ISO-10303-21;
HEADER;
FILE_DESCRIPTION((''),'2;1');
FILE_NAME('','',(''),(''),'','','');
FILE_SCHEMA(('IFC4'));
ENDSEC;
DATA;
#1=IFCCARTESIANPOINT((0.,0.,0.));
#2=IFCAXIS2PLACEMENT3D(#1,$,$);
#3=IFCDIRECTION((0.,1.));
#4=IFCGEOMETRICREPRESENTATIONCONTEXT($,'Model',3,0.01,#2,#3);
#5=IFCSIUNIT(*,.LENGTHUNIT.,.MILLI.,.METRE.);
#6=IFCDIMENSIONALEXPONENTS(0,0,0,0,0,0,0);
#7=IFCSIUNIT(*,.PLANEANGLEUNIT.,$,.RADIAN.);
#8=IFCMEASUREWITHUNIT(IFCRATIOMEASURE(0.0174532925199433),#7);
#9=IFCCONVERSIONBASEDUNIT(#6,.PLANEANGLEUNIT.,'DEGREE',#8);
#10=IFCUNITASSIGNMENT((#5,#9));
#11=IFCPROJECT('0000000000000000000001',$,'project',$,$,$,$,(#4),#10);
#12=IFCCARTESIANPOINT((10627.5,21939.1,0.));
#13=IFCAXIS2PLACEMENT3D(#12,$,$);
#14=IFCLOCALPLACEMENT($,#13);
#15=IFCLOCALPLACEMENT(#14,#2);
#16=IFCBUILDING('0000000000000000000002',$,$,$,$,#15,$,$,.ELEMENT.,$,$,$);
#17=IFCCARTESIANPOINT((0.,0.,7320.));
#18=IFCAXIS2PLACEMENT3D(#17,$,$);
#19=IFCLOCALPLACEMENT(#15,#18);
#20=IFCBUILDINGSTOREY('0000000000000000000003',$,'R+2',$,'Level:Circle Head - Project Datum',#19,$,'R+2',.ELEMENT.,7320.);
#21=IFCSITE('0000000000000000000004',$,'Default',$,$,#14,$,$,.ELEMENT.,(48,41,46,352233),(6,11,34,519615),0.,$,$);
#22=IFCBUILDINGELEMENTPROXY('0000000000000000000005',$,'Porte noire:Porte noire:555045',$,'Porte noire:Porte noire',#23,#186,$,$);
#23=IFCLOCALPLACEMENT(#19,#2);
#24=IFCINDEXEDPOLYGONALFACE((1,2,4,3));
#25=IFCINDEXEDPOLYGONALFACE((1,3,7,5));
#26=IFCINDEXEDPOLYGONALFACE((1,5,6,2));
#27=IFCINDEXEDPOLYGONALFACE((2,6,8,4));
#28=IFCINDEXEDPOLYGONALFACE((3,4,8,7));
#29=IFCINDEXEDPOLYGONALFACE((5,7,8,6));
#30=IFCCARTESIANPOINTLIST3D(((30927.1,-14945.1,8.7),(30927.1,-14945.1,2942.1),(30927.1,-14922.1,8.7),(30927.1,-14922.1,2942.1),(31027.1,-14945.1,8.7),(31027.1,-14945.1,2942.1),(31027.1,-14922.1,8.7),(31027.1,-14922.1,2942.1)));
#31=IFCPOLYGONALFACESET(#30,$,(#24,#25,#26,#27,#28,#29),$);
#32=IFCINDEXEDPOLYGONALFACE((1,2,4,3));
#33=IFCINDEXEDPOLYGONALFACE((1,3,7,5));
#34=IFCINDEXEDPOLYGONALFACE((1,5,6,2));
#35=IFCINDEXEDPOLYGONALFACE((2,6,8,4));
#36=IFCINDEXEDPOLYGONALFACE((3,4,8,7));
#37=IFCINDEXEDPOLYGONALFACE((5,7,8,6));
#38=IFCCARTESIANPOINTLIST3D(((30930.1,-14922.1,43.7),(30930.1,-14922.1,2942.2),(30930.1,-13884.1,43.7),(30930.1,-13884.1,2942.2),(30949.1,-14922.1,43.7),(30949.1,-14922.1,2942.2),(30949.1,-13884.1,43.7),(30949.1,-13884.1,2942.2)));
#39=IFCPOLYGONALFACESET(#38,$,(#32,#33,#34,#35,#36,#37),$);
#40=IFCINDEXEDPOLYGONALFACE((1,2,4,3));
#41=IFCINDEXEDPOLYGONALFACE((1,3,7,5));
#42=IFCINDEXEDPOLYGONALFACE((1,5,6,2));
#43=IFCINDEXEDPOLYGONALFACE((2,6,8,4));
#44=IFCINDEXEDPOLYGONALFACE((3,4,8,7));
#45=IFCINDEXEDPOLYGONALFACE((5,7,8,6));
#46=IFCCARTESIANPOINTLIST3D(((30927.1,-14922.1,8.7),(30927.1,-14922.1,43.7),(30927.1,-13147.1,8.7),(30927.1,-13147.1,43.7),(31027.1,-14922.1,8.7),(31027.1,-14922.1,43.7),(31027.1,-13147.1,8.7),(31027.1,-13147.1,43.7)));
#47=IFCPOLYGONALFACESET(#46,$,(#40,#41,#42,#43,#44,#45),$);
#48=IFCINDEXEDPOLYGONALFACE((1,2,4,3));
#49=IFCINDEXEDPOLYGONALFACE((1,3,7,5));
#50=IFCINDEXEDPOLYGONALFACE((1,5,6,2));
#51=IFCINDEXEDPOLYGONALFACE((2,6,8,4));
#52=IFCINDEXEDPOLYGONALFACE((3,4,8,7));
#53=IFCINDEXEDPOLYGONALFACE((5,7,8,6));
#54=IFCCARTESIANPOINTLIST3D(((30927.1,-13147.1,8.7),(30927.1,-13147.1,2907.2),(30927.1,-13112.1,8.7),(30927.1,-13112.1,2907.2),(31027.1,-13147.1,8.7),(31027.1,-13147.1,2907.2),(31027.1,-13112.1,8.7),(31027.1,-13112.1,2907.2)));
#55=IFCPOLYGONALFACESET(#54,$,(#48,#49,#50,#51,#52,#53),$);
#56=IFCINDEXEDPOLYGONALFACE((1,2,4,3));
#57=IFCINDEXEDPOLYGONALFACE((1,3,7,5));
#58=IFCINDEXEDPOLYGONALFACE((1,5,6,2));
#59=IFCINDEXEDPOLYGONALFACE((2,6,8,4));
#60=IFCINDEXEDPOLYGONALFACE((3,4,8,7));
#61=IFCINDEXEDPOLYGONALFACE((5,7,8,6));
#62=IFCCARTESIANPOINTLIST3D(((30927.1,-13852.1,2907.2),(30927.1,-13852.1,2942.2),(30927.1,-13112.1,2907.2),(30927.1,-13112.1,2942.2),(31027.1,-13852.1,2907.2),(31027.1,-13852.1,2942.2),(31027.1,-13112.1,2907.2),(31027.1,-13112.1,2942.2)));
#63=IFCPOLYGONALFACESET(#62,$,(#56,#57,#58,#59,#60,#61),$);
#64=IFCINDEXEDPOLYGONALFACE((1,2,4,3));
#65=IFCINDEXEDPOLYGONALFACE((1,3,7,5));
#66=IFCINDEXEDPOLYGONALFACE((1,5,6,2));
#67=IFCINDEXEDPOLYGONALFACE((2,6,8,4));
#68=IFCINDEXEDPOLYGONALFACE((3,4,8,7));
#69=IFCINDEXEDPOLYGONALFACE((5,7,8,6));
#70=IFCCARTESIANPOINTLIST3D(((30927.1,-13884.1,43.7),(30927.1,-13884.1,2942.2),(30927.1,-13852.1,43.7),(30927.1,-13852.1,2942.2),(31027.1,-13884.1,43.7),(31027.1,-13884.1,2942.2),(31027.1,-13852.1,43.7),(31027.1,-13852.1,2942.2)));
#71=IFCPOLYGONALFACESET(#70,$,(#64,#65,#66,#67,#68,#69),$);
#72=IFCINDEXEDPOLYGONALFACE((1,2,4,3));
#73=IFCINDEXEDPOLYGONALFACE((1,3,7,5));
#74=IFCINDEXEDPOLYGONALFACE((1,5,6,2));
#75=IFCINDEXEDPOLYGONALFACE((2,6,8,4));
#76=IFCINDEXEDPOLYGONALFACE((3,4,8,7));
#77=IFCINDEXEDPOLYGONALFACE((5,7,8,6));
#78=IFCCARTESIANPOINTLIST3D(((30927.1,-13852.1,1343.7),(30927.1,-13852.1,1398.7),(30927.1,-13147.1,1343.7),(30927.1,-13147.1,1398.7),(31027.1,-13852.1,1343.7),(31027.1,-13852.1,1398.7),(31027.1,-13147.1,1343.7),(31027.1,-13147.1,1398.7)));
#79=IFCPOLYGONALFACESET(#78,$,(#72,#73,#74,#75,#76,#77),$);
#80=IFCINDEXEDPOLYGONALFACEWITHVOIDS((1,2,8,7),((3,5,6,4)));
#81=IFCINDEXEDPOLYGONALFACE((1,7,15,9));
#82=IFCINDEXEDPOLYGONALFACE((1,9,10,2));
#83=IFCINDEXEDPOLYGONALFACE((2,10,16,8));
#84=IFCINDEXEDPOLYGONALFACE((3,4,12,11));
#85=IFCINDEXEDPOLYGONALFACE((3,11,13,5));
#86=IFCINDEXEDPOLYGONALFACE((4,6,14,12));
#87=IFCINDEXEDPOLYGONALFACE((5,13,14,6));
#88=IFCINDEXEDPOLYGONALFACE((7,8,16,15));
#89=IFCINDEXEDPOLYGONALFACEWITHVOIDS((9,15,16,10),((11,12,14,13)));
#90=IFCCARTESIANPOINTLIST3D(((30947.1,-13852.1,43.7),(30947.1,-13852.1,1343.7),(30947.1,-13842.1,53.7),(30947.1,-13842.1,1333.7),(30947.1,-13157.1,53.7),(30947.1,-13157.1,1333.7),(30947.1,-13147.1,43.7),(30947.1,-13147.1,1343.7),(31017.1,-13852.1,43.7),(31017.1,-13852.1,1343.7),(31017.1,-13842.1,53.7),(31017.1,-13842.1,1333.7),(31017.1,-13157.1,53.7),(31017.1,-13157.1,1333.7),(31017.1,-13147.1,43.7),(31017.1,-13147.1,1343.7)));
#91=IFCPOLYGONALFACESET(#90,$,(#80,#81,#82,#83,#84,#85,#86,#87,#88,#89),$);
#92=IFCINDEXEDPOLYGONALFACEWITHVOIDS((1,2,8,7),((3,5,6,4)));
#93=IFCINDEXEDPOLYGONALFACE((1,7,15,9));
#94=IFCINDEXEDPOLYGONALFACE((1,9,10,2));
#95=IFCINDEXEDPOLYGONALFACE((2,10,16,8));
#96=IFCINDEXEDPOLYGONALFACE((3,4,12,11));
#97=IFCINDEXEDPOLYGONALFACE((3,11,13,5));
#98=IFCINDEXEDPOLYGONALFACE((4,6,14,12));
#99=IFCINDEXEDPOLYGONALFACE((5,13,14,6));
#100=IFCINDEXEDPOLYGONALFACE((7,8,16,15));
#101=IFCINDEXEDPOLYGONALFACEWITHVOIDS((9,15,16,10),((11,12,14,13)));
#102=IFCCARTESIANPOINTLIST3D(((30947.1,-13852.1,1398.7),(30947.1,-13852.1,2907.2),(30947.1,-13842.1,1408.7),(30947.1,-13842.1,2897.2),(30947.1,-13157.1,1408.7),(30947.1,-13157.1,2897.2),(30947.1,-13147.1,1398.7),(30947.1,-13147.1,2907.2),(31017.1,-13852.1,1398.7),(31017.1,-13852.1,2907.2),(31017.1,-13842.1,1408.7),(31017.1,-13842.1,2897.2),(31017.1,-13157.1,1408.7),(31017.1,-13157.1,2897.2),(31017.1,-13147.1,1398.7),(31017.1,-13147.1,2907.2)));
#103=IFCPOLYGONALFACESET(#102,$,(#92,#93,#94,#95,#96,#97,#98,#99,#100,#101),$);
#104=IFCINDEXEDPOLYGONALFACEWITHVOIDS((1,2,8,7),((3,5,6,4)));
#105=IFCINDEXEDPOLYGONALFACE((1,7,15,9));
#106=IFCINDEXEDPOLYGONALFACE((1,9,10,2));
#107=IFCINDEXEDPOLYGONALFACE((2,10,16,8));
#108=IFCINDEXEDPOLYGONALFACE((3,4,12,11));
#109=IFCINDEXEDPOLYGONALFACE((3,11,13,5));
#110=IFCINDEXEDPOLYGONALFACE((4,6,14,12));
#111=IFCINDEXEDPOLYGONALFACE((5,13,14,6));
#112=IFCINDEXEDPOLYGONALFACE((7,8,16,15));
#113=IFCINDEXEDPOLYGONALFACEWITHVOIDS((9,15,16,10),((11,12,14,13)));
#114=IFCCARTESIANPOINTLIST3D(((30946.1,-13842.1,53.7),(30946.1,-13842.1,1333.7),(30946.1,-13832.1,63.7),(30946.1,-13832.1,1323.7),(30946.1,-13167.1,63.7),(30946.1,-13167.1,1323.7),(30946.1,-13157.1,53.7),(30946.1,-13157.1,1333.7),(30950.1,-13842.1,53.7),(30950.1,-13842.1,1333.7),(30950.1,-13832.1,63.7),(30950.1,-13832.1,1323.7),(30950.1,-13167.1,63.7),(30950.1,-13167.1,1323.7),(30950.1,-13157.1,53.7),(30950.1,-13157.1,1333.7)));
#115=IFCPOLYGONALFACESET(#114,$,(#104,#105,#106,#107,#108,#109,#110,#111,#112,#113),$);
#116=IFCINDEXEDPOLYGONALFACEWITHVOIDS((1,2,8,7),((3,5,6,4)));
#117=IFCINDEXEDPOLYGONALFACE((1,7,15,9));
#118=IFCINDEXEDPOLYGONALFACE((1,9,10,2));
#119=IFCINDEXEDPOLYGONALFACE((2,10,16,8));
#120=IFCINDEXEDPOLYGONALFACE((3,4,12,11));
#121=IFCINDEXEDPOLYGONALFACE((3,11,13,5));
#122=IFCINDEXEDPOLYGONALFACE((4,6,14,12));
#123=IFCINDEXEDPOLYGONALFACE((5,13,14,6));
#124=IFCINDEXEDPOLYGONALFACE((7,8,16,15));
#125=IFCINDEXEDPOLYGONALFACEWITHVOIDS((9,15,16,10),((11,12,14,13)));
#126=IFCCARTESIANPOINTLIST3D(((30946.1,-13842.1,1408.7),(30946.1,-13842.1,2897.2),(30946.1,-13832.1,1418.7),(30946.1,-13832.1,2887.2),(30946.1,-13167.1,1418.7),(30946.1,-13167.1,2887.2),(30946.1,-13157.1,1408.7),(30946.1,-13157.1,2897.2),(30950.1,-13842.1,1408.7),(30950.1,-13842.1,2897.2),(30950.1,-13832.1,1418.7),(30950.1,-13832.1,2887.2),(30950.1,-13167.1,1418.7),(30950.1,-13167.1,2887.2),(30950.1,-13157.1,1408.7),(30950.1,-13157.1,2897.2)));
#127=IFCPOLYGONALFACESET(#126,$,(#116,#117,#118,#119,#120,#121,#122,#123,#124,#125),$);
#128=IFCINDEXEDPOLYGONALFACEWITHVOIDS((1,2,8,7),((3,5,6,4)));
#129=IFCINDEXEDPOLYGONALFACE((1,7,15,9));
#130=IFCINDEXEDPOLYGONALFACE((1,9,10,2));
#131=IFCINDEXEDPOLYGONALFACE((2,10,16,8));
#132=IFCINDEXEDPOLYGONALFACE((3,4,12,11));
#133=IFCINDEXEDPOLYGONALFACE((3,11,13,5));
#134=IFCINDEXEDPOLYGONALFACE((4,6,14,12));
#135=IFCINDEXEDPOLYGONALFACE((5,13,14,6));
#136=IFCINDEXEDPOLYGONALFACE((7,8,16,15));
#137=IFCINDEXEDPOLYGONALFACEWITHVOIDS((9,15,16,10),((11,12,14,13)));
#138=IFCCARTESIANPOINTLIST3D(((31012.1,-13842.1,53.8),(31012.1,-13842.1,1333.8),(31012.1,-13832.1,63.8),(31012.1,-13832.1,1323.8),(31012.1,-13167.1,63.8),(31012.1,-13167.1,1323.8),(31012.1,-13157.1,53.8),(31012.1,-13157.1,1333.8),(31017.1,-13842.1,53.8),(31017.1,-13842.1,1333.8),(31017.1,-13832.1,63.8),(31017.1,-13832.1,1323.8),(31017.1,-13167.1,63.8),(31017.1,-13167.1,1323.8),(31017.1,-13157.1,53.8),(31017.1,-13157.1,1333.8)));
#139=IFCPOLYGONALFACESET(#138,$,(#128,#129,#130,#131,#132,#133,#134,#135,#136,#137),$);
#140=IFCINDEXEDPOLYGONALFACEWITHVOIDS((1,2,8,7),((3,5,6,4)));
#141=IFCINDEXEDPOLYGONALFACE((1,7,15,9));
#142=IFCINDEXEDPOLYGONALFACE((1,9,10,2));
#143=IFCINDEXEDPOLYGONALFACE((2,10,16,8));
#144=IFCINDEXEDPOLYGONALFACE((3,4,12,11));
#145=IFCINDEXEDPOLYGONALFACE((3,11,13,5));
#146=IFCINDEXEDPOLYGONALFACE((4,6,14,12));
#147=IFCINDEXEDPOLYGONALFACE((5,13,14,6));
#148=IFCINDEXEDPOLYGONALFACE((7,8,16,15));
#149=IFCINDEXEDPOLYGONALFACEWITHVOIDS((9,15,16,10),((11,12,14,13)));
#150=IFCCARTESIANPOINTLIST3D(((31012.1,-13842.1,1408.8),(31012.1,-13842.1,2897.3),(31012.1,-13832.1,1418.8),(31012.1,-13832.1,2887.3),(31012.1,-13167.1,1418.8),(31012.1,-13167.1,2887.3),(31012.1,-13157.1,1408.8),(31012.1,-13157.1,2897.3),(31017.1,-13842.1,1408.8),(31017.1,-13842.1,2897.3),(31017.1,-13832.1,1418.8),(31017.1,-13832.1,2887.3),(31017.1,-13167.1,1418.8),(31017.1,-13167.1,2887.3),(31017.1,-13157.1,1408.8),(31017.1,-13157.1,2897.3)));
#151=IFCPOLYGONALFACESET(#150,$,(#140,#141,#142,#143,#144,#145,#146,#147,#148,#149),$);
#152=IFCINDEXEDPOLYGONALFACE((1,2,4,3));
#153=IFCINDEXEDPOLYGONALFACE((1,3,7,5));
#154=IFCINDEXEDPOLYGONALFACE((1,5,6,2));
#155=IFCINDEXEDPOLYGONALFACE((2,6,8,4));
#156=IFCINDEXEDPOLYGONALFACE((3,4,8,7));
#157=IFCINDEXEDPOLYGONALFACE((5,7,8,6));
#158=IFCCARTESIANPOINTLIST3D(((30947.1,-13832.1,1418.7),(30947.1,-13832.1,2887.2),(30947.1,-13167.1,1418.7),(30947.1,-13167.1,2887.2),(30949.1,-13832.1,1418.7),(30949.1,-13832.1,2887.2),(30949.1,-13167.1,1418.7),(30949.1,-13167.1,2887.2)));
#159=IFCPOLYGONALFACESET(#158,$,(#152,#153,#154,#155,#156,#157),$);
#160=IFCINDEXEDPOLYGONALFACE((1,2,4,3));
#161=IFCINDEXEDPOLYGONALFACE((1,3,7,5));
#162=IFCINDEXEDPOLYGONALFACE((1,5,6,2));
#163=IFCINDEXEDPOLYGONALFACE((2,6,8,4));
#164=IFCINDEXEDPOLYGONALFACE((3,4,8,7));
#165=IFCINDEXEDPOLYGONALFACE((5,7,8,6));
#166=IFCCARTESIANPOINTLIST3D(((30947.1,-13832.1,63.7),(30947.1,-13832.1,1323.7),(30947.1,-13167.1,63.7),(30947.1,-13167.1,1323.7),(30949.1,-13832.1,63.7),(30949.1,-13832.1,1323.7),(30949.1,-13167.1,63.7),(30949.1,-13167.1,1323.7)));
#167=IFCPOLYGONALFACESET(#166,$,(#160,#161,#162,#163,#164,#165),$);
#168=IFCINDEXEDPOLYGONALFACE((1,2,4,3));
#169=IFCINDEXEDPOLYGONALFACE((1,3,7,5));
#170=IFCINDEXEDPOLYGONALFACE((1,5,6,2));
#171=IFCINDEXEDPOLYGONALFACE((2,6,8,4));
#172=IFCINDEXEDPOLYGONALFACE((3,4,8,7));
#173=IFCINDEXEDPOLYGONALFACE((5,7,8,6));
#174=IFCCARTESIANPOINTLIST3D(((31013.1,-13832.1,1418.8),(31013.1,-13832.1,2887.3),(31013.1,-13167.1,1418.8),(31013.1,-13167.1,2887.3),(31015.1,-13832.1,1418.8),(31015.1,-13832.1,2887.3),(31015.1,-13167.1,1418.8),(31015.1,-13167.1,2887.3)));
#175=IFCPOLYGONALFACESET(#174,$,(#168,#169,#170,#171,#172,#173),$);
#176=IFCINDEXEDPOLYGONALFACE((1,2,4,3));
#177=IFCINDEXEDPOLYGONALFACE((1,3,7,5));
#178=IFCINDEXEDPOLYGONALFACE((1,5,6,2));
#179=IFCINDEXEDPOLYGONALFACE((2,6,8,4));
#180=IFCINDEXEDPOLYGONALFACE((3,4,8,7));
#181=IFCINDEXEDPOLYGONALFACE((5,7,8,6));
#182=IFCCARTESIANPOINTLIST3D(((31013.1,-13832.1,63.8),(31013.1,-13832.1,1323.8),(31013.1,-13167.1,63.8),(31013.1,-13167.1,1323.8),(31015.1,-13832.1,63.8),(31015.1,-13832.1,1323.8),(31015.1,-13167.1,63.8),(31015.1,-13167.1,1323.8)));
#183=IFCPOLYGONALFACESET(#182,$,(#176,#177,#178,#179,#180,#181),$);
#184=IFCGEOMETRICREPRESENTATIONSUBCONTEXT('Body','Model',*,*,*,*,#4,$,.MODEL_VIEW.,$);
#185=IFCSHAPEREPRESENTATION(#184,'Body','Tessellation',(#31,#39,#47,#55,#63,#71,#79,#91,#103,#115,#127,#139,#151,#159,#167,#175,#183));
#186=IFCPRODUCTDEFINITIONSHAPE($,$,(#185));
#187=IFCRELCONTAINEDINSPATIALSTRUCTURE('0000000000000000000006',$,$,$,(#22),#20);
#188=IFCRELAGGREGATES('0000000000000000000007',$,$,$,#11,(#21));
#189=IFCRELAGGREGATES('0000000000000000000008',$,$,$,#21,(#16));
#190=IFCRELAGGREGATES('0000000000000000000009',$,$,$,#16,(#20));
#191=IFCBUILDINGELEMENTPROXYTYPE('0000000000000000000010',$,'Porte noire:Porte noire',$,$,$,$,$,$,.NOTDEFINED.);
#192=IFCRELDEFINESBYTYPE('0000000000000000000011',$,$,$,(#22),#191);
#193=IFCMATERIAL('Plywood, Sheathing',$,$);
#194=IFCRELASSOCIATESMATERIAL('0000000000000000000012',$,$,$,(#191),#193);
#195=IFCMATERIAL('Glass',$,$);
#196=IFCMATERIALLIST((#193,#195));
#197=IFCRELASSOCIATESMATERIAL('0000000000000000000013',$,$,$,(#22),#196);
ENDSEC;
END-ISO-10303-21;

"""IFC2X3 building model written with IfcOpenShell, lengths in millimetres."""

from ifc_helpers import new_model, entity, si_unit, converted_unit, direction, frame, frame_2d, origin, origin_2d_with_axis, place, context, subcontext, project, spatial, polyline, rectangle, outline, extrude, source, transform, mapped, material, material_list, type_object, type_shapes, element, save


model = new_model("IFC2X3")

# Units and contexts
model_context = context("Model", 3, precision=0.01, world=origin(), true_north=direction((0.0, 1.0)))
body_context = subcontext(model_context, "Body", "Model", "MODEL_VIEW")
ifc_project = project(units=[si_unit("LENGTHUNIT", "METRE", prefix="MILLI"), converted_unit("PLANEANGLEUNIT", "DEGREE", entity("IfcRatioMeasure", 0.0174532925199433), si_unit("PLANEANGLEUNIT", "RADIAN"), dimensions=[0, 0, 0, 0, 0, 0, 0])], contexts=[model_context])

# Site, building, storey
site_placement = place(None, frame((10627.5, 21939.1, 0.0)))
site = spatial("IfcSite", under=ifc_project, at=site_placement, Name="Default", CompositionType="ELEMENT", RefLatitude=(48, 41, 46, 352233), RefLongitude=(6, 11, 34, 519615), RefElevation=0.0)
building_placement = place(site_placement, origin())
building = spatial("IfcBuilding", under=site, at=building_placement, CompositionType="ELEMENT")
storey_placement = place(building_placement, frame((0.0, 0.0, 7320.0)))
storey = spatial("IfcBuildingStorey", under=building, at=storey_placement, Name="R+2", ObjectType="Level:Circle Head - Project Datum", LongName="R+2", CompositionType="ELEMENT", Elevation=7320.0)

# Building element proxy
ifc_material_1 = material(Name="Plywood, Sheathing")
ifc_material_2 = material(Name="Glass")
ifc_material_list_1 = material_list([ifc_material_1, ifc_material_2])
building_element_proxy_type_1 = type_object("IfcBuildingElementProxyType", Name="Porte noire:Porte noire", PredefinedType="NOTDEFINED", material=ifc_material_1)
shared_shape_1 = source(origin(), body_context, "Body", "SweptSolid", [
    extrude(rectangle(XDim=23.0, YDim=100.0, at=frame_2d((0.0, 0.0), x_axis=(1.0, 0.0))), frame((-950.9, 50.0, 8.7), z_axis=(0.0, 0.0, 1.0), x_axis=(-1.0, 0.0, 0.0)), (0.0, 0.0, 1.0), 2933.3),
    extrude(rectangle(XDim=1038.0, YDim=19.0, at=frame_2d((0.0, 0.0), x_axis=(1.0, 0.0))), frame((-420.4, 87.5, 43.7), z_axis=(0.0, 0.0, 1.0), x_axis=(-1.0, 0.0, 0.0)), (0.0, 0.0, 1.0), 2898.5),
    extrude(rectangle(XDim=1775.0, YDim=100.0, at=origin_2d_with_axis()), frame((-51.9, 50.0, 8.7), z_axis=(0.0, 0.0, 1.0), x_axis=(-1.0, 0.0, 0.0)), (0.0, 0.0, 1.0), 35.0),
    extrude(rectangle(XDim=35.0, YDim=100.0, at=origin_2d_with_axis()), frame((853.1, 50.0, 8.7), z_axis=(0.0, 0.0, 1.0), x_axis=(-1.0, 0.0, 0.0)), (0.0, 0.0, 1.0), 2898.5),
    extrude(rectangle(XDim=740.0, YDim=100.0, at=origin_2d_with_axis()), frame((500.6, 50.0, 2907.2), z_axis=(0.0, 0.0, 1.0), x_axis=(-1.0, 0.0, 0.0)), (0.0, 0.0, 1.0), 35.0),
    extrude(rectangle(XDim=32.0, YDim=100.0, at=origin_2d_with_axis()), frame((114.6, 50.0, 43.7), z_axis=(0.0, 0.0, 1.0), x_axis=(-1.0, 0.0, 0.0)), (0.0, 0.0, 1.0), 2898.5),
    extrude(rectangle(XDim=705.0, YDim=100.0, at=origin_2d_with_axis()), frame((483.1, 50.0, 1343.7), z_axis=(0.0, 0.0, 1.0), x_axis=(-1.0, 0.0, 0.0)), (0.0, 0.0, 1.0), 55.0),
    extrude(outline(polyline([(-352.5, -650.0), (352.5, -650.0), (352.5, 650.0), (-352.5, 650.0), (-352.5, -650.0)]), holes=[polyline([(342.5, 640.0), (342.5, -640.0), (-342.5, -640.0), (-342.5, 640.0), (342.5, 640.0)])]), frame((483.1, 10.0, 693.7), z_axis=(0.0, 1.0, 0.0), x_axis=(1.0, 0.0, 0.0)), (0.0, 0.0, 1.0), 70.0),
    extrude(outline(polyline([(-754.2, -352.5), (754.2, -352.5), (754.2, 352.5), (-754.2, 352.5), (-754.2, -352.5)]), holes=[polyline([(744.2, 342.5), (744.2, -342.5), (-744.2, -342.5), (-744.2, 342.5), (744.2, 342.5)])]), frame((483.1, 10.0, 2153.0), z_axis=(0.0, 1.0, 0.0), x_axis=(0.0, 0.0, 1.0)), (0.0, 0.0, 1.0), 70.0),
    extrude(outline(polyline([(-640.0, -342.5), (640.0, -342.5), (640.0, 342.5), (-640.0, 342.5), (-640.0, -342.5)]), holes=[polyline([(630.0, 332.5), (630.0, -332.5), (-630.0, -332.5), (-630.0, 332.5), (630.0, 332.5)])]), frame((483.1, 77.0, 693.7), z_axis=(0.0, 1.0, 0.0), x_axis=(0.0, 0.0, 1.0)), (0.0, 0.0, 1.0), 4.0),
    extrude(outline(polyline([(-744.2, -342.5), (744.2, -342.5), (744.2, 342.5), (-744.2, 342.5), (-744.2, -342.5)]), holes=[polyline([(734.2, 332.5), (734.2, -332.5), (-734.2, -332.5), (-734.2, 332.5), (734.2, 332.5)])]), frame((483.1, 77.0, 2153.0), z_axis=(0.0, 1.0, 0.0), x_axis=(0.0, 0.0, 1.0)), (0.0, 0.0, 1.0), 4.0),
    extrude(outline(polyline([(-640.0, -342.5), (640.0, -342.5), (640.0, 342.5), (-640.0, 342.5), (-640.0, -342.5)]), holes=[polyline([(630.0, 332.5), (630.0, -332.5), (-630.0, -332.5), (-630.0, 332.5), (630.0, 332.5)])]), frame((483.1, 10.0, 693.8), z_axis=(0.0, 1.0, 0.0), x_axis=(0.0, 0.0, 1.0)), (0.0, 0.0, 1.0), 5.0),
    extrude(outline(polyline([(-744.2, -342.5), (744.2, -342.5), (744.2, 342.5), (-744.2, 342.5), (-744.2, -342.5)]), holes=[polyline([(734.2, 332.5), (734.2, -332.5), (-734.2, -332.5), (-734.2, 332.5), (734.2, 332.5)])]), frame((483.1, 10.0, 2153.0), z_axis=(0.0, 1.0, 0.0), x_axis=(0.0, 0.0, 1.0)), (0.0, 0.0, 1.0), 5.0),
    extrude(rectangle(XDim=665.0, YDim=2.0, at=frame_2d((0.0, 0.0), x_axis=(1.0, 0.0))), frame((483.1, 79.0, 1418.7), z_axis=(0.0, 0.0, 1.0), x_axis=(-1.0, 0.0, 0.0)), (0.0, 0.0, 1.0), 1468.5),
    extrude(rectangle(XDim=665.0, YDim=2.0, at=frame_2d((0.0, 0.0), x_axis=(1.0, 0.0))), frame((483.1, 79.0, 63.7), z_axis=(0.0, 0.0, 1.0), x_axis=(-1.0, 0.0, 0.0)), (0.0, 0.0, 1.0), 1260.0),
    extrude(rectangle(XDim=665.0, YDim=2.0, at=frame_2d((0.0, 0.0), x_axis=(1.0, 0.0))), frame((483.1, 13.0, 1418.8), z_axis=(0.0, 0.0, 1.0), x_axis=(-1.0, 0.0, 0.0)), (0.0, 0.0, 1.0), 1468.5),
    extrude(rectangle(XDim=665.0, YDim=2.0, at=frame_2d((0.0, 0.0), x_axis=(1.0, 0.0))), frame((483.1, 13.0, 63.8), z_axis=(0.0, 0.0, 1.0), x_axis=(-1.0, 0.0, 0.0)), (0.0, 0.0, 1.0), 1260.0),
])
type_shapes(building_element_proxy_type_1, [shared_shape_1])
proxy_1_placement = place(storey_placement, frame((31027.1, -13982.7, 0.0), z_axis=(0.0, 0.0, 1.0), x_axis=(0.0, 1.0, 0.0)))
element("IfcBuildingElementProxy", 1, at=proxy_1_placement, inside=storey, type_object=building_element_proxy_type_1, material=ifc_material_list_1, Name="Porte noire:Porte noire:555045", ObjectType="Porte noire:Porte noire", context=body_context, shape_type="MappedRepresentation", body=[
    mapped(shared_shape_1, transform((0.0, 0.0, 0.0), scale=1.0)),
])

save(model, "model.ifc")
